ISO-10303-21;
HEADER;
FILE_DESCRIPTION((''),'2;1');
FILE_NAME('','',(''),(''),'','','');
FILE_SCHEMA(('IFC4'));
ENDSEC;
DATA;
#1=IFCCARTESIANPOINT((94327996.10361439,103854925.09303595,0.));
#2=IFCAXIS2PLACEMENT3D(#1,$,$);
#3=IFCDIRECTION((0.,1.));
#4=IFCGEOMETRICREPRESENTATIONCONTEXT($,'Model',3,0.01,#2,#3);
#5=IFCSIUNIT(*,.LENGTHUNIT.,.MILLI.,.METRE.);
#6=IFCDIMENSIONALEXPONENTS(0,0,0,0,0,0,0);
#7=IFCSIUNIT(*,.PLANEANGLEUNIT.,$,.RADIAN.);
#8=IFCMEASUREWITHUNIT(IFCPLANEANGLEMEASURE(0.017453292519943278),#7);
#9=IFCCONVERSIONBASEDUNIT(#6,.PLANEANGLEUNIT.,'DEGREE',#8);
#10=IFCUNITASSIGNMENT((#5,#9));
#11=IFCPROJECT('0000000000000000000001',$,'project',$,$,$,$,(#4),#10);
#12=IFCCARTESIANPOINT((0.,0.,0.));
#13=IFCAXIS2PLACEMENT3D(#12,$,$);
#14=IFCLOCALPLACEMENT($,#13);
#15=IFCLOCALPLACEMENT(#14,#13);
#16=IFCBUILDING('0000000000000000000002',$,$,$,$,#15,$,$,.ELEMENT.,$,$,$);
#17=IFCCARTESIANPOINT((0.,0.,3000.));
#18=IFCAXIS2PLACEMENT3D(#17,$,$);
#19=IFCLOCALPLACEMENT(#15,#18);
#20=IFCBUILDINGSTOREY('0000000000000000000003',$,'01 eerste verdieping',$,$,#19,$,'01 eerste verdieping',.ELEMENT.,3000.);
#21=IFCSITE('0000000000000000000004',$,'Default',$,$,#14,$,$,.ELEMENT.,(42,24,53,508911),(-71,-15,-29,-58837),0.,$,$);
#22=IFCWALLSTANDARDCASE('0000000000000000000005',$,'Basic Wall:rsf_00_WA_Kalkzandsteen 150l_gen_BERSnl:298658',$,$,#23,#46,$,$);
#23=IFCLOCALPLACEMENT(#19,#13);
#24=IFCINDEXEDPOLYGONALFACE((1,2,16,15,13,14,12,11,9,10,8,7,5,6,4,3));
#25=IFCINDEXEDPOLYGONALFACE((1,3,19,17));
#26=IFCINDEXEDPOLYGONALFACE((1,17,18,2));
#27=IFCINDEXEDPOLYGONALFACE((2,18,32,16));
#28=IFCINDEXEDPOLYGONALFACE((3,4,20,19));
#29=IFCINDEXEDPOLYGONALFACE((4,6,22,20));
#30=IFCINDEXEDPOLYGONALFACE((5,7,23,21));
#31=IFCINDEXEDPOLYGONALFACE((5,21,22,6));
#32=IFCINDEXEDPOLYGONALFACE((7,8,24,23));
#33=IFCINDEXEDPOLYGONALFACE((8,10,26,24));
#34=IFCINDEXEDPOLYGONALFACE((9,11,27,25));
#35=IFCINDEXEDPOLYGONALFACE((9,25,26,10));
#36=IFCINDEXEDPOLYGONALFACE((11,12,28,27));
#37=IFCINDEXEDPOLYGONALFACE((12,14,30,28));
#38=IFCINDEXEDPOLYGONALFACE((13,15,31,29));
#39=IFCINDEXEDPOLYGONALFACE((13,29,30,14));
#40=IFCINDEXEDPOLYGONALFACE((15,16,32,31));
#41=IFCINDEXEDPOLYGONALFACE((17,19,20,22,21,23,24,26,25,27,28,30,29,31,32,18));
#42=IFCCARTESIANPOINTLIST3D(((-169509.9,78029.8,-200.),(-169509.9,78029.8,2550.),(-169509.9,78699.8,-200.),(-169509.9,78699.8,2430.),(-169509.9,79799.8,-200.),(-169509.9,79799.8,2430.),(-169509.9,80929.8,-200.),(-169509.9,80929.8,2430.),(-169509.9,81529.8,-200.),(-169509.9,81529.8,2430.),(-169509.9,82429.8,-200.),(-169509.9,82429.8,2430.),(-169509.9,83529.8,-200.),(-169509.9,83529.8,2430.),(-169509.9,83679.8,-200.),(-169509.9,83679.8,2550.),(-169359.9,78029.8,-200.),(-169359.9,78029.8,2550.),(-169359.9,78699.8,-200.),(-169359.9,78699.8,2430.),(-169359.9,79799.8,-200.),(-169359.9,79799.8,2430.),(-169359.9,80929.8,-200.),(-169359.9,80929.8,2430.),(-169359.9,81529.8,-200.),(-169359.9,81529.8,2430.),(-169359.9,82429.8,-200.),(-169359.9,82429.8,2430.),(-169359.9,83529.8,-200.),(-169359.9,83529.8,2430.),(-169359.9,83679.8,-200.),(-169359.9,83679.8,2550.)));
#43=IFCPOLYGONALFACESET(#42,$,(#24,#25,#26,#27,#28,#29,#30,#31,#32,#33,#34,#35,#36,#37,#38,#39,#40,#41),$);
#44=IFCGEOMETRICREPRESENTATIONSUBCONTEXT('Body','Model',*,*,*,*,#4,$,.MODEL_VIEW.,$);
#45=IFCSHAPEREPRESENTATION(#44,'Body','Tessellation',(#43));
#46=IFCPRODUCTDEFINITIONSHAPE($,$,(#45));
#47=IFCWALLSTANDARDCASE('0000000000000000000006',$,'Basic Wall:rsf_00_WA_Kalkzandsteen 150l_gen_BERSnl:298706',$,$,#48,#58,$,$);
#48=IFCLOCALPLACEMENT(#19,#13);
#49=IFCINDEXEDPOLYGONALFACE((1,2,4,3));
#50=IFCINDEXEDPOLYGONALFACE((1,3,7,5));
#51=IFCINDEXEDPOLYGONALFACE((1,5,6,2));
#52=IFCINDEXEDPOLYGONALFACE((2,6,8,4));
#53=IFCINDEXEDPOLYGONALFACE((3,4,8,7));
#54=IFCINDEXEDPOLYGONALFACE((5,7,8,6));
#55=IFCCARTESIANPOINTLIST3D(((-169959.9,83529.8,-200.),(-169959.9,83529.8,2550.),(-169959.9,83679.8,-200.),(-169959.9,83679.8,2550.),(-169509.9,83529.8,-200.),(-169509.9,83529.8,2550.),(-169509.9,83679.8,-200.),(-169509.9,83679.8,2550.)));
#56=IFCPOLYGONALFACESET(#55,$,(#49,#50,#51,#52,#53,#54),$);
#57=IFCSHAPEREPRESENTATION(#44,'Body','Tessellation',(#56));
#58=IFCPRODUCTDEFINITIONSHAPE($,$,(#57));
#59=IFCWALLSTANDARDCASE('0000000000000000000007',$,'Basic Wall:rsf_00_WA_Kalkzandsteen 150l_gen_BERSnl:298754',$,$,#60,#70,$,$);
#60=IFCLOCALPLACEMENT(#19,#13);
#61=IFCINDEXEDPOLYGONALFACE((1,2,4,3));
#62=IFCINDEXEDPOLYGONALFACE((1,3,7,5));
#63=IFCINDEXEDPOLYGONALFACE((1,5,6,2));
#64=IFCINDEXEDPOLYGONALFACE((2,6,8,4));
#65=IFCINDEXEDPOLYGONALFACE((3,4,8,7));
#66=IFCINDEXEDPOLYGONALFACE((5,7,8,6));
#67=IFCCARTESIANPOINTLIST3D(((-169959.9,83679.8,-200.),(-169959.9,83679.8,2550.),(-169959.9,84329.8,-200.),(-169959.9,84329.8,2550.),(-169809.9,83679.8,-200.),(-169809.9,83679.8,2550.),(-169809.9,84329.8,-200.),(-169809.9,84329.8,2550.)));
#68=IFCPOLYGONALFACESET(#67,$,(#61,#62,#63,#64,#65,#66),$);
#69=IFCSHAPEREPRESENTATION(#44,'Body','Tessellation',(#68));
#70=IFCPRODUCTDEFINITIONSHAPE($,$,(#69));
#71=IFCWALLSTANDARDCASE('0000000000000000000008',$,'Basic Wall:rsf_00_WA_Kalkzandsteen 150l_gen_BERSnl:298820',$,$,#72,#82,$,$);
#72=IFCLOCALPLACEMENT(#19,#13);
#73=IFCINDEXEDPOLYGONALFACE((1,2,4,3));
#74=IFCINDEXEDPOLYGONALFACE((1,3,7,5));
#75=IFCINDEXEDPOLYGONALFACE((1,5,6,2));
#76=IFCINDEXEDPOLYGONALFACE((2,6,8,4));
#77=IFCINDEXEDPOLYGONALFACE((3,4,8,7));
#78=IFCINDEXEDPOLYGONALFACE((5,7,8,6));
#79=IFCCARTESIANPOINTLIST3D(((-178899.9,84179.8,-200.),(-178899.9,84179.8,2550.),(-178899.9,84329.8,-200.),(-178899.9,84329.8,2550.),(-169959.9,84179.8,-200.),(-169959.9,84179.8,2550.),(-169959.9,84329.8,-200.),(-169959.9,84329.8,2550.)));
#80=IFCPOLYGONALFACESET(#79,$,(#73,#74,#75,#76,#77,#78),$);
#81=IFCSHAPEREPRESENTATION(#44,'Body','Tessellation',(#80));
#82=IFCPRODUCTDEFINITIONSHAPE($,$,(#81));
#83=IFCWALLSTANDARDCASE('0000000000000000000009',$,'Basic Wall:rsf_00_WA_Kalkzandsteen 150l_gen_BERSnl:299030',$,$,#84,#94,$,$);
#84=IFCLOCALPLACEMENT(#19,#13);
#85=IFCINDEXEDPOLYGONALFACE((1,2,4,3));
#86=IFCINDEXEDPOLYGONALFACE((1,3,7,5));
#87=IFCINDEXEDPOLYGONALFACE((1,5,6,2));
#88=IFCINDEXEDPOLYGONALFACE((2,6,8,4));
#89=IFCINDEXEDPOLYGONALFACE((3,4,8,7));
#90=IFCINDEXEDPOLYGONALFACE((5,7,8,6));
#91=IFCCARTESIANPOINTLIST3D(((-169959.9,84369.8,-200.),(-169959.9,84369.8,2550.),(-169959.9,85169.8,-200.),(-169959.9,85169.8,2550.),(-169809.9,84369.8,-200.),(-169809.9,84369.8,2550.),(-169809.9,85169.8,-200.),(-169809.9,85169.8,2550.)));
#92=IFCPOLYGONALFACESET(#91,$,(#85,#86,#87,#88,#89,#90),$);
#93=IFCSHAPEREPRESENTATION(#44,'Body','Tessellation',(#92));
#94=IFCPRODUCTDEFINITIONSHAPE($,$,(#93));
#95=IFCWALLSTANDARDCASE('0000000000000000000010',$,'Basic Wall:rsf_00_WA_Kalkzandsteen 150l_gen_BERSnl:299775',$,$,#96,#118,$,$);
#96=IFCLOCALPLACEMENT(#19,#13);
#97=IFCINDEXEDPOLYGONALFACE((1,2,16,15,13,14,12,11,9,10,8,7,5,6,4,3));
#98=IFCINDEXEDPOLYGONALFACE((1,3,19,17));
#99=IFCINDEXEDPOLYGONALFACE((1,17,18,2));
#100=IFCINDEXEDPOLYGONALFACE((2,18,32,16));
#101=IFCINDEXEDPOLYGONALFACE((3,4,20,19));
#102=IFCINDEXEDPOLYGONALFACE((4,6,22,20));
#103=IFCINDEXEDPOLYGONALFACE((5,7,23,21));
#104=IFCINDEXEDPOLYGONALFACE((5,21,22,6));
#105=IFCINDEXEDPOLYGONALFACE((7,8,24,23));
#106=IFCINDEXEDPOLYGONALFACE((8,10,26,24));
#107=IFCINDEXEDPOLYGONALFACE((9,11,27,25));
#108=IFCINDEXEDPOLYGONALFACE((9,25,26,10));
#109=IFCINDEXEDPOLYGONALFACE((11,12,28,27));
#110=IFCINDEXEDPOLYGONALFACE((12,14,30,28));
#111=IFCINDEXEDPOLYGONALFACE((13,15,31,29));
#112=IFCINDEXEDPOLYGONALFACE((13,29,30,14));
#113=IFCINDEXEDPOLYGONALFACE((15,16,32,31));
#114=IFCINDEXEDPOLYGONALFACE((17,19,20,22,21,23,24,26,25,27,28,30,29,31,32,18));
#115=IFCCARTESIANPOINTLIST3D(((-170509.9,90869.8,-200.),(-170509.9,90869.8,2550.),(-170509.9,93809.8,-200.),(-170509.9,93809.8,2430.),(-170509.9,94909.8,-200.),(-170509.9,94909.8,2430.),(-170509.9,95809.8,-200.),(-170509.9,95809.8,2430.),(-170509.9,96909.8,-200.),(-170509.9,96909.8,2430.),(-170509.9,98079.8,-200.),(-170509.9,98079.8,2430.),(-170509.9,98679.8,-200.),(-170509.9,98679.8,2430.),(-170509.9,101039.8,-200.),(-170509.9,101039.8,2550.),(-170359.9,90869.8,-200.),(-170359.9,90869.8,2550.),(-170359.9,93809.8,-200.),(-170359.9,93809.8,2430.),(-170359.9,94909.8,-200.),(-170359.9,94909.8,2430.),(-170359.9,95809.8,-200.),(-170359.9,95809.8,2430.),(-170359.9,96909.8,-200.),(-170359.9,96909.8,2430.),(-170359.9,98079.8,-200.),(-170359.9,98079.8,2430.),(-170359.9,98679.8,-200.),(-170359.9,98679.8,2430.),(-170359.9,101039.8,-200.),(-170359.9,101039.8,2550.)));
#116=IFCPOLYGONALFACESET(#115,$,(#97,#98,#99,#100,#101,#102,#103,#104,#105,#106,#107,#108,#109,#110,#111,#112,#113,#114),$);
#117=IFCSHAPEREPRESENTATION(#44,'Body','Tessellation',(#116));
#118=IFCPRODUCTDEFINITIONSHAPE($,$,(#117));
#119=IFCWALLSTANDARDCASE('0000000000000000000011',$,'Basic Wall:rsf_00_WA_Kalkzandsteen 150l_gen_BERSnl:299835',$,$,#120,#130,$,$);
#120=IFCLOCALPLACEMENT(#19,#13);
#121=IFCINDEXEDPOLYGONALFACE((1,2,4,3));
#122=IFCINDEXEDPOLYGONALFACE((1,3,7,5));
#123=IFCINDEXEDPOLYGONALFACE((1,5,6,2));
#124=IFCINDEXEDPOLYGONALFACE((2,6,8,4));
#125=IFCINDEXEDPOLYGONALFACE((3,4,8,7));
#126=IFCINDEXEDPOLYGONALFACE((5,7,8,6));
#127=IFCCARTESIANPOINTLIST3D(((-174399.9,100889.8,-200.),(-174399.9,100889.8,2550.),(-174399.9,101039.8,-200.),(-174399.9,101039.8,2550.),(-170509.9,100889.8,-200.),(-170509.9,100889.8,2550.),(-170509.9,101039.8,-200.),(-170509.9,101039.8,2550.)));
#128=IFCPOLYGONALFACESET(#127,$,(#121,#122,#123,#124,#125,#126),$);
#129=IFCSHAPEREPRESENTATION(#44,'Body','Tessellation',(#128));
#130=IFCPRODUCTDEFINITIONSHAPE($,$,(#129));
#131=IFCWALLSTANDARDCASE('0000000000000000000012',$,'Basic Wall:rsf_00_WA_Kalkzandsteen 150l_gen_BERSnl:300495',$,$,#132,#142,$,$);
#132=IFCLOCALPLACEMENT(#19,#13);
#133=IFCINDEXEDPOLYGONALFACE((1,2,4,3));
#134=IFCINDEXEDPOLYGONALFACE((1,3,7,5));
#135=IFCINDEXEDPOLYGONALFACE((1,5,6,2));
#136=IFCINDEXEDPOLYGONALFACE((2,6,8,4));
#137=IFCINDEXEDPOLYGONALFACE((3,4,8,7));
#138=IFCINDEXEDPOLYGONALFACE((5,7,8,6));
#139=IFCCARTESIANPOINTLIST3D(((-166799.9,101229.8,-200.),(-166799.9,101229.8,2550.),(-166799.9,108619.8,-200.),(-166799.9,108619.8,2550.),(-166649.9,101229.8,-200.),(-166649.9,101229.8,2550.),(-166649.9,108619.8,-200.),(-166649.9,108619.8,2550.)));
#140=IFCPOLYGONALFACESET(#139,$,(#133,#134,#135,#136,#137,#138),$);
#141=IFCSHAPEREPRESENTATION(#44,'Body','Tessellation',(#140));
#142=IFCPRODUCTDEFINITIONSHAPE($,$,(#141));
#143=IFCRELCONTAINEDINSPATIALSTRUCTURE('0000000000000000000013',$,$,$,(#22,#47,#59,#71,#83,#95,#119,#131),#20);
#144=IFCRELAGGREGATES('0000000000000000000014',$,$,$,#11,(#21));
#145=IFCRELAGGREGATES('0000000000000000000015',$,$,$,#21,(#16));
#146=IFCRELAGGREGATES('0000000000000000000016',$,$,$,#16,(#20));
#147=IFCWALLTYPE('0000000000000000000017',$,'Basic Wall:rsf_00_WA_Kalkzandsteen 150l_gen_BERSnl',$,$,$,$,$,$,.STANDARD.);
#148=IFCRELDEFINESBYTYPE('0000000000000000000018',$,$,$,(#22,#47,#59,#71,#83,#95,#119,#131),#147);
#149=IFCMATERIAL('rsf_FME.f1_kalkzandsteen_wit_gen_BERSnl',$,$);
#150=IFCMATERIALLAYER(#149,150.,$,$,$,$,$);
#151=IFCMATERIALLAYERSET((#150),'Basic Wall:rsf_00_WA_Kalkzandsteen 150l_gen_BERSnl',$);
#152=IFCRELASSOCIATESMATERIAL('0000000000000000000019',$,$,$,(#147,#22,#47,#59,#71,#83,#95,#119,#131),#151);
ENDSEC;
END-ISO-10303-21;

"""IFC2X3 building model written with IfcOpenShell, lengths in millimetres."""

from ifc_helpers import new_model, entity, si_unit, converted_unit, direction, frame, frame_2d, origin, origin_2d_with_axis, place, context, subcontext, project, spatial, polyline, rectangle, extrude, clip, bounded_halfspace, material, layer, layer_set, layer_usage, type_object, element, save


model = new_model("IFC2X3")

# Units and contexts
model_context = context("Model", 3, precision=0.01, world=frame((94327996.10361439, 103854925.09303595, 0.0)), true_north=direction((0.0, 1.0)))
body_context = subcontext(model_context, "Body", "Model", "MODEL_VIEW")
ifc_project = project(units=[si_unit("LENGTHUNIT", "METRE", prefix="MILLI"), converted_unit("PLANEANGLEUNIT", "DEGREE", entity("IfcPlaneAngleMeasure", 0.017453292519943278), si_unit("PLANEANGLEUNIT", "RADIAN"), dimensions=[0, 0, 0, 0, 0, 0, 0])], contexts=[model_context])

# Site, building, storey
site_placement = place(None, origin())
site = spatial("IfcSite", under=ifc_project, at=site_placement, Name="Default", CompositionType="ELEMENT", RefLatitude=(42, 24, 53, 508911), RefLongitude=(-71, -15, -29, -58837), RefElevation=0.0)
building_placement = place(site_placement, origin())
building = spatial("IfcBuilding", under=site, at=building_placement, CompositionType="ELEMENT")
storey_placement = place(building_placement, frame((0.0, 0.0, 3000.0)))
storey = spatial("IfcBuildingStorey", under=building, at=storey_placement, Name="01 eerste verdieping", LongName="01 eerste verdieping", CompositionType="ELEMENT", Elevation=3000.0)

# Wall, openings
ifc_material = material(Name="rsf_FME.f1_kalkzandsteen_wit_gen_BERSnl")
ifc_layer = layer(ifc_material, 150.0)
ifc_layer_set = layer_set([ifc_layer], Name="Basic Wall:rsf_00_WA_Kalkzandsteen 150l_gen_BERSnl")
ifc_layer_usage_1 = layer_usage(ifc_layer_set, "AXIS2", "NEGATIVE", 75.0)
wall_type = type_object("IfcWallType", Name="Basic Wall:rsf_00_WA_Kalkzandsteen 150l_gen_BERSnl", PredefinedType="STANDARD", material=ifc_layer_set)
wall_1_placement = place(storey_placement, frame((-169434.9, 78029.8, -200.0), z_axis=(0.0, 0.0, 1.0), x_axis=(0.0, 1.0, 0.0)))
wall_1 = element("IfcWallStandardCase", 1, at=wall_1_placement, inside=storey, type_object=wall_type, material=ifc_layer_usage_1, Name="Basic Wall:rsf_00_WA_Kalkzandsteen 150l_gen_BERSnl:298658", context=body_context, shape_type="Clipping", body=[
    clip(extrude(rectangle(XDim=5650.0, YDim=150.0, at=frame_2d((2825.0, 0.0), x_axis=(1.0, 0.0))), origin(), (0.0, 0.0, 1.0), 2750.0), bounded_halfspace(frame((0.0, -75.0, 2750.0), z_axis=(0.0, 0.0, -1.0), x_axis=(1.0, 0.0, 0.0)), True, frame((0.0, -75.0, 2750.0)), polyline([(0.0, 0.0), (5650.0, 0.0), (5650.0, 150.0), (5500.0, 150.0), (0.0, 150.0), (0.0, 0.0)]))),
])
opening_1_placement = place(wall_1_placement, frame((-78029.8, -169434.9, 200.0), z_axis=(0.0, 0.0, 1.0), x_axis=(0.0, -1.0, 0.0)))
element("IfcOpeningElement", 2, at=opening_1_placement, cuts=wall_1, ObjectType="Opening", context=body_context, shape_type="SweptSolid", body=[
    extrude(rectangle(XDim=2630.0, YDim=1100.0, at=frame_2d((0.0, 0.0), x_axis=(1.0, 0.0))), frame((-167985.9, 79249.8, 1115.0), z_axis=(-1.0, 0.0, 0.0), x_axis=(0.0, 0.0, 1.0)), (0.0, 0.0, 1.0), 3048.0),
])
opening_2_placement = place(wall_1_placement, frame((-78029.8, -169434.9, 200.0), z_axis=(0.0, 0.0, 1.0), x_axis=(0.0, -1.0, 0.0)))
element("IfcOpeningElement", 3, at=opening_2_placement, cuts=wall_1, ObjectType="Opening", context=body_context, shape_type="SweptSolid", body=[
    extrude(rectangle(XDim=2630.0, YDim=1100.0, at=frame_2d((0.0, 0.0), x_axis=(1.0, 0.0))), frame((-167985.9, 82979.8, 1115.0), z_axis=(-1.0, 0.0, 0.0), x_axis=(0.0, 0.0, 1.0)), (0.0, 0.0, 1.0), 3048.0),
])
opening_3_placement = place(wall_1_placement, frame((-78029.8, -169434.9, 200.0), z_axis=(0.0, 0.0, 1.0), x_axis=(0.0, -1.0, 0.0)))
element("IfcOpeningElement", 4, at=opening_3_placement, cuts=wall_1, ObjectType="Opening", context=body_context, shape_type="SweptSolid", body=[
    extrude(rectangle(XDim=2630.0, YDim=600.0, at=origin_2d_with_axis()), frame((-167985.9, 81229.8, 1115.0), z_axis=(-1.0, 0.0, 0.0), x_axis=(0.0, 0.0, 1.0)), (0.0, 0.0, 1.0), 3048.0),
])

# Walls
ifc_layer_usage_2 = layer_usage(ifc_layer_set, "AXIS2", "NEGATIVE", 75.0)
wall_2_placement = place(storey_placement, frame((-169509.9, 83604.8, -200.0), z_axis=(0.0, 0.0, 1.0), x_axis=(-1.0, 0.0, 0.0)))
element("IfcWallStandardCase", 5, at=wall_2_placement, inside=storey, type_object=wall_type, material=ifc_layer_usage_2, Name="Basic Wall:rsf_00_WA_Kalkzandsteen 150l_gen_BERSnl:298706", context=body_context, shape_type="Clipping", body=[
    clip(extrude(rectangle(XDim=450.0, YDim=150.0, at=frame_2d((225.0, 0.0), x_axis=(-1.0, 0.0))), origin(), (0.0, 0.0, 1.0), 2750.0), bounded_halfspace(frame((0.0, -75.0, 2750.0), z_axis=(0.0, 0.0, -1.0), x_axis=(0.0, -1.0, 0.0)), True, frame((0.0, -75.0, 2750.0)), polyline([(0.0, 0.0), (300.0, 0.0), (450.0, 0.0), (450.0, 150.0), (0.0, 150.0), (0.0, 0.0)]))),
])
ifc_layer_usage_3 = layer_usage(ifc_layer_set, "AXIS2", "NEGATIVE", 75.0)
wall_3_placement = place(storey_placement, frame((-169884.9, 83679.8, -200.0), z_axis=(0.0, 0.0, 1.0), x_axis=(0.0, 1.0, 0.0)))
element("IfcWallStandardCase", 6, at=wall_3_placement, inside=storey, type_object=wall_type, material=ifc_layer_usage_3, Name="Basic Wall:rsf_00_WA_Kalkzandsteen 150l_gen_BERSnl:298754", context=body_context, shape_type="Clipping", body=[
    clip(extrude(rectangle(XDim=650.0, YDim=150.0, at=frame_2d((325.0, 0.0), x_axis=(-1.0, 0.0))), origin(), (0.0, 0.0, 1.0), 2750.0), bounded_halfspace(frame((0.0, -75.0, 2750.0), z_axis=(0.0, 0.0, -1.0), x_axis=(1.0, 0.0, 0.0)), True, frame((0.0, -75.0, 2750.0)), polyline([(0.0, 0.0), (650.0, 0.0), (650.0, 150.0), (500.0, 150.0), (0.0, 150.0), (0.0, 0.0)]))),
])
ifc_layer_usage_4 = layer_usage(ifc_layer_set, "AXIS2", "NEGATIVE", 75.0)
wall_4_placement = place(storey_placement, frame((-169959.9, 84254.8, -200.0), z_axis=(0.0, 0.0, 1.0), x_axis=(-1.0, 0.0, 0.0)))
element("IfcWallStandardCase", 7, at=wall_4_placement, inside=storey, type_object=wall_type, material=ifc_layer_usage_4, Name="Basic Wall:rsf_00_WA_Kalkzandsteen 150l_gen_BERSnl:298820", context=body_context, shape_type="Clipping", body=[
    clip(extrude(rectangle(XDim=8940.0, YDim=150.0, at=frame_2d((4470.0, 0.0), x_axis=(-1.0, 0.0))), origin(), (0.0, 0.0, 1.0), 2750.0), bounded_halfspace(frame((0.0, -75.0, 2750.0), z_axis=(0.0, 0.0, -1.0), x_axis=(0.0, -1.0, 0.0)), True, frame((0.0, -75.0, 2750.0)), polyline([(0.0, 0.0), (8940.0, 0.0), (8940.0, 150.0), (8790.0, 150.0), (0.0, 150.0), (0.0, 0.0)]))),
])
ifc_layer_usage_5 = layer_usage(ifc_layer_set, "AXIS2", "NEGATIVE", 75.0)
wall_5_placement = place(storey_placement, frame((-169884.9, 84369.8, -200.0), z_axis=(0.0, 0.0, 1.0), x_axis=(0.0, 1.0, 0.0)))
element("IfcWallStandardCase", 8, at=wall_5_placement, inside=storey, type_object=wall_type, material=ifc_layer_usage_5, Name="Basic Wall:rsf_00_WA_Kalkzandsteen 150l_gen_BERSnl:299030", context=body_context, shape_type="Clipping", body=[
    clip(extrude(rectangle(XDim=800.0, YDim=150.0, at=frame_2d((400.0, 0.0), x_axis=(-1.0, 0.0))), origin(), (0.0, 0.0, 1.0), 2750.0), bounded_halfspace(frame((0.0, -75.0, 2750.0), z_axis=(0.0, 0.0, -1.0), x_axis=(1.0, 0.0, 0.0)), True, frame((0.0, -75.0, 2750.0)), polyline([(0.0, 0.0), (650.0, 0.0), (800.0, 0.0), (800.0, 150.0), (150.0, 150.0), (0.0, 150.0), (0.0, 0.0)]))),
])

# Wall, openings
ifc_layer_usage_6 = layer_usage(ifc_layer_set, "AXIS2", "NEGATIVE", 75.0)
wall_6_placement = place(storey_placement, frame((-170434.9, 90869.8, -200.0), z_axis=(0.0, 0.0, 1.0), x_axis=(0.0, 1.0, 0.0)))
wall_6 = element("IfcWallStandardCase", 9, at=wall_6_placement, inside=storey, type_object=wall_type, material=ifc_layer_usage_6, Name="Basic Wall:rsf_00_WA_Kalkzandsteen 150l_gen_BERSnl:299775", context=body_context, shape_type="Clipping", body=[
    clip(extrude(rectangle(XDim=10170.0, YDim=150.0, at=frame_2d((5085.0, 0.0), x_axis=(1.0, 0.0))), origin(), (0.0, 0.0, 1.0), 2750.0), bounded_halfspace(frame((0.0, -75.0, 2750.0), z_axis=(0.0, 0.0, -1.0), x_axis=(1.0, 0.0, 0.0)), True, frame((0.0, -75.0, 2750.0)), polyline([(0.0, 0.0), (10170.0, 0.0), (10170.0, 150.0), (10020.0, 150.0), (150.0, 150.0), (0.0, 150.0), (0.0, 0.0)]))),
])
opening_4_placement = place(wall_6_placement, frame((-90869.8, -170434.9, 200.0), z_axis=(0.0, 0.0, 1.0), x_axis=(0.0, -1.0, 0.0)))
element("IfcOpeningElement", 10, at=opening_4_placement, cuts=wall_6, ObjectType="Opening", context=body_context, shape_type="SweptSolid", body=[
    extrude(rectangle(XDim=2630.0, YDim=1100.0, at=frame_2d((0.0, 0.0), x_axis=(1.0, 0.0))), frame((-168985.9, 94359.8, 1115.0), z_axis=(-1.0, 0.0, 0.0), x_axis=(0.0, 0.0, 1.0)), (0.0, 0.0, 1.0), 3048.0),
])
opening_5_placement = place(wall_6_placement, frame((-90869.8, -170434.9, 200.0), z_axis=(0.0, 0.0, 1.0), x_axis=(0.0, -1.0, 0.0)))
element("IfcOpeningElement", 11, at=opening_5_placement, cuts=wall_6, ObjectType="Opening", context=body_context, shape_type="SweptSolid", body=[
    extrude(rectangle(XDim=2630.0, YDim=1100.0, at=frame_2d((0.0, 0.0), x_axis=(0.0, 1.0))), frame((-168835.9, 96359.8, 1115.0), z_axis=(-1.0, 0.0, 0.0), x_axis=(0.0, -1.0, 0.0)), (0.0, 0.0, 1.0), 3048.0),
])
opening_6_placement = place(wall_6_placement, frame((-90869.8, -170434.9, 200.0), z_axis=(0.0, 0.0, 1.0), x_axis=(0.0, -1.0, 0.0)))
element("IfcOpeningElement", 12, at=opening_6_placement, cuts=wall_6, ObjectType="Opening", context=body_context, shape_type="SweptSolid", body=[
    extrude(rectangle(XDim=2630.0, YDim=600.0, at=frame_2d((0.0, 0.0), x_axis=(0.0, 1.0))), frame((-168835.9, 98379.8, 1115.0), z_axis=(-1.0, 0.0, 0.0), x_axis=(0.0, -1.0, 0.0)), (0.0, 0.0, 1.0), 3048.0),
])

# Walls
ifc_layer_usage_7 = layer_usage(ifc_layer_set, "AXIS2", "NEGATIVE", 75.0)
wall_7_placement = place(storey_placement, frame((-170509.9, 100964.8, -200.0), z_axis=(0.0, 0.0, 1.0), x_axis=(-1.0, 0.0, 0.0)))
element("IfcWallStandardCase", 13, at=wall_7_placement, inside=storey, type_object=wall_type, material=ifc_layer_usage_7, Name="Basic Wall:rsf_00_WA_Kalkzandsteen 150l_gen_BERSnl:299835", context=body_context, shape_type="Clipping", body=[
    clip(extrude(rectangle(XDim=3890.0, YDim=150.0, at=frame_2d((1945.0, 0.0), x_axis=(-1.0, 0.0))), origin(), (0.0, 0.0, 1.0), 2750.0), bounded_halfspace(frame((0.0, -75.0, 2750.0), z_axis=(0.0, 0.0, -1.0), x_axis=(0.0, -1.0, 0.0)), True, frame((0.0, -75.0, 2750.0)), polyline([(0.0, 0.0), (3890.0, 0.0), (3890.0, 150.0), (3740.0, 150.0), (0.0, 150.0), (0.0, 0.0)]))),
])
ifc_layer_usage_8 = layer_usage(ifc_layer_set, "AXIS2", "NEGATIVE", 75.0)
wall_8_placement = place(storey_placement, frame((-166724.9, 101229.8, -200.0), z_axis=(0.0, 0.0, 1.0), x_axis=(0.0, 1.0, 0.0)))
element("IfcWallStandardCase", 14, at=wall_8_placement, inside=storey, type_object=wall_type, material=ifc_layer_usage_8, Name="Basic Wall:rsf_00_WA_Kalkzandsteen 150l_gen_BERSnl:300495", context=body_context, shape_type="Clipping", body=[
    clip(extrude(rectangle(XDim=7390.0, YDim=150.0, at=frame_2d((3695.0, 0.0), x_axis=(-1.0, 0.0))), origin(), (0.0, 0.0, 1.0), 2750.0), bounded_halfspace(frame((0.0, -75.0, 2750.0), z_axis=(0.0, 0.0, -1.0), x_axis=(1.0, 0.0, 0.0)), True, frame((0.0, -75.0, 2750.0)), polyline([(0.0, 0.0), (250.0, 0.0), (7390.0, 0.0), (7390.0, 150.0), (7240.0, 150.0), (4679.5, 150.0), (4529.5, 150.0), (0.0, 150.0), (0.0, 0.0)]))),
])

save(model, "model.ifc")
